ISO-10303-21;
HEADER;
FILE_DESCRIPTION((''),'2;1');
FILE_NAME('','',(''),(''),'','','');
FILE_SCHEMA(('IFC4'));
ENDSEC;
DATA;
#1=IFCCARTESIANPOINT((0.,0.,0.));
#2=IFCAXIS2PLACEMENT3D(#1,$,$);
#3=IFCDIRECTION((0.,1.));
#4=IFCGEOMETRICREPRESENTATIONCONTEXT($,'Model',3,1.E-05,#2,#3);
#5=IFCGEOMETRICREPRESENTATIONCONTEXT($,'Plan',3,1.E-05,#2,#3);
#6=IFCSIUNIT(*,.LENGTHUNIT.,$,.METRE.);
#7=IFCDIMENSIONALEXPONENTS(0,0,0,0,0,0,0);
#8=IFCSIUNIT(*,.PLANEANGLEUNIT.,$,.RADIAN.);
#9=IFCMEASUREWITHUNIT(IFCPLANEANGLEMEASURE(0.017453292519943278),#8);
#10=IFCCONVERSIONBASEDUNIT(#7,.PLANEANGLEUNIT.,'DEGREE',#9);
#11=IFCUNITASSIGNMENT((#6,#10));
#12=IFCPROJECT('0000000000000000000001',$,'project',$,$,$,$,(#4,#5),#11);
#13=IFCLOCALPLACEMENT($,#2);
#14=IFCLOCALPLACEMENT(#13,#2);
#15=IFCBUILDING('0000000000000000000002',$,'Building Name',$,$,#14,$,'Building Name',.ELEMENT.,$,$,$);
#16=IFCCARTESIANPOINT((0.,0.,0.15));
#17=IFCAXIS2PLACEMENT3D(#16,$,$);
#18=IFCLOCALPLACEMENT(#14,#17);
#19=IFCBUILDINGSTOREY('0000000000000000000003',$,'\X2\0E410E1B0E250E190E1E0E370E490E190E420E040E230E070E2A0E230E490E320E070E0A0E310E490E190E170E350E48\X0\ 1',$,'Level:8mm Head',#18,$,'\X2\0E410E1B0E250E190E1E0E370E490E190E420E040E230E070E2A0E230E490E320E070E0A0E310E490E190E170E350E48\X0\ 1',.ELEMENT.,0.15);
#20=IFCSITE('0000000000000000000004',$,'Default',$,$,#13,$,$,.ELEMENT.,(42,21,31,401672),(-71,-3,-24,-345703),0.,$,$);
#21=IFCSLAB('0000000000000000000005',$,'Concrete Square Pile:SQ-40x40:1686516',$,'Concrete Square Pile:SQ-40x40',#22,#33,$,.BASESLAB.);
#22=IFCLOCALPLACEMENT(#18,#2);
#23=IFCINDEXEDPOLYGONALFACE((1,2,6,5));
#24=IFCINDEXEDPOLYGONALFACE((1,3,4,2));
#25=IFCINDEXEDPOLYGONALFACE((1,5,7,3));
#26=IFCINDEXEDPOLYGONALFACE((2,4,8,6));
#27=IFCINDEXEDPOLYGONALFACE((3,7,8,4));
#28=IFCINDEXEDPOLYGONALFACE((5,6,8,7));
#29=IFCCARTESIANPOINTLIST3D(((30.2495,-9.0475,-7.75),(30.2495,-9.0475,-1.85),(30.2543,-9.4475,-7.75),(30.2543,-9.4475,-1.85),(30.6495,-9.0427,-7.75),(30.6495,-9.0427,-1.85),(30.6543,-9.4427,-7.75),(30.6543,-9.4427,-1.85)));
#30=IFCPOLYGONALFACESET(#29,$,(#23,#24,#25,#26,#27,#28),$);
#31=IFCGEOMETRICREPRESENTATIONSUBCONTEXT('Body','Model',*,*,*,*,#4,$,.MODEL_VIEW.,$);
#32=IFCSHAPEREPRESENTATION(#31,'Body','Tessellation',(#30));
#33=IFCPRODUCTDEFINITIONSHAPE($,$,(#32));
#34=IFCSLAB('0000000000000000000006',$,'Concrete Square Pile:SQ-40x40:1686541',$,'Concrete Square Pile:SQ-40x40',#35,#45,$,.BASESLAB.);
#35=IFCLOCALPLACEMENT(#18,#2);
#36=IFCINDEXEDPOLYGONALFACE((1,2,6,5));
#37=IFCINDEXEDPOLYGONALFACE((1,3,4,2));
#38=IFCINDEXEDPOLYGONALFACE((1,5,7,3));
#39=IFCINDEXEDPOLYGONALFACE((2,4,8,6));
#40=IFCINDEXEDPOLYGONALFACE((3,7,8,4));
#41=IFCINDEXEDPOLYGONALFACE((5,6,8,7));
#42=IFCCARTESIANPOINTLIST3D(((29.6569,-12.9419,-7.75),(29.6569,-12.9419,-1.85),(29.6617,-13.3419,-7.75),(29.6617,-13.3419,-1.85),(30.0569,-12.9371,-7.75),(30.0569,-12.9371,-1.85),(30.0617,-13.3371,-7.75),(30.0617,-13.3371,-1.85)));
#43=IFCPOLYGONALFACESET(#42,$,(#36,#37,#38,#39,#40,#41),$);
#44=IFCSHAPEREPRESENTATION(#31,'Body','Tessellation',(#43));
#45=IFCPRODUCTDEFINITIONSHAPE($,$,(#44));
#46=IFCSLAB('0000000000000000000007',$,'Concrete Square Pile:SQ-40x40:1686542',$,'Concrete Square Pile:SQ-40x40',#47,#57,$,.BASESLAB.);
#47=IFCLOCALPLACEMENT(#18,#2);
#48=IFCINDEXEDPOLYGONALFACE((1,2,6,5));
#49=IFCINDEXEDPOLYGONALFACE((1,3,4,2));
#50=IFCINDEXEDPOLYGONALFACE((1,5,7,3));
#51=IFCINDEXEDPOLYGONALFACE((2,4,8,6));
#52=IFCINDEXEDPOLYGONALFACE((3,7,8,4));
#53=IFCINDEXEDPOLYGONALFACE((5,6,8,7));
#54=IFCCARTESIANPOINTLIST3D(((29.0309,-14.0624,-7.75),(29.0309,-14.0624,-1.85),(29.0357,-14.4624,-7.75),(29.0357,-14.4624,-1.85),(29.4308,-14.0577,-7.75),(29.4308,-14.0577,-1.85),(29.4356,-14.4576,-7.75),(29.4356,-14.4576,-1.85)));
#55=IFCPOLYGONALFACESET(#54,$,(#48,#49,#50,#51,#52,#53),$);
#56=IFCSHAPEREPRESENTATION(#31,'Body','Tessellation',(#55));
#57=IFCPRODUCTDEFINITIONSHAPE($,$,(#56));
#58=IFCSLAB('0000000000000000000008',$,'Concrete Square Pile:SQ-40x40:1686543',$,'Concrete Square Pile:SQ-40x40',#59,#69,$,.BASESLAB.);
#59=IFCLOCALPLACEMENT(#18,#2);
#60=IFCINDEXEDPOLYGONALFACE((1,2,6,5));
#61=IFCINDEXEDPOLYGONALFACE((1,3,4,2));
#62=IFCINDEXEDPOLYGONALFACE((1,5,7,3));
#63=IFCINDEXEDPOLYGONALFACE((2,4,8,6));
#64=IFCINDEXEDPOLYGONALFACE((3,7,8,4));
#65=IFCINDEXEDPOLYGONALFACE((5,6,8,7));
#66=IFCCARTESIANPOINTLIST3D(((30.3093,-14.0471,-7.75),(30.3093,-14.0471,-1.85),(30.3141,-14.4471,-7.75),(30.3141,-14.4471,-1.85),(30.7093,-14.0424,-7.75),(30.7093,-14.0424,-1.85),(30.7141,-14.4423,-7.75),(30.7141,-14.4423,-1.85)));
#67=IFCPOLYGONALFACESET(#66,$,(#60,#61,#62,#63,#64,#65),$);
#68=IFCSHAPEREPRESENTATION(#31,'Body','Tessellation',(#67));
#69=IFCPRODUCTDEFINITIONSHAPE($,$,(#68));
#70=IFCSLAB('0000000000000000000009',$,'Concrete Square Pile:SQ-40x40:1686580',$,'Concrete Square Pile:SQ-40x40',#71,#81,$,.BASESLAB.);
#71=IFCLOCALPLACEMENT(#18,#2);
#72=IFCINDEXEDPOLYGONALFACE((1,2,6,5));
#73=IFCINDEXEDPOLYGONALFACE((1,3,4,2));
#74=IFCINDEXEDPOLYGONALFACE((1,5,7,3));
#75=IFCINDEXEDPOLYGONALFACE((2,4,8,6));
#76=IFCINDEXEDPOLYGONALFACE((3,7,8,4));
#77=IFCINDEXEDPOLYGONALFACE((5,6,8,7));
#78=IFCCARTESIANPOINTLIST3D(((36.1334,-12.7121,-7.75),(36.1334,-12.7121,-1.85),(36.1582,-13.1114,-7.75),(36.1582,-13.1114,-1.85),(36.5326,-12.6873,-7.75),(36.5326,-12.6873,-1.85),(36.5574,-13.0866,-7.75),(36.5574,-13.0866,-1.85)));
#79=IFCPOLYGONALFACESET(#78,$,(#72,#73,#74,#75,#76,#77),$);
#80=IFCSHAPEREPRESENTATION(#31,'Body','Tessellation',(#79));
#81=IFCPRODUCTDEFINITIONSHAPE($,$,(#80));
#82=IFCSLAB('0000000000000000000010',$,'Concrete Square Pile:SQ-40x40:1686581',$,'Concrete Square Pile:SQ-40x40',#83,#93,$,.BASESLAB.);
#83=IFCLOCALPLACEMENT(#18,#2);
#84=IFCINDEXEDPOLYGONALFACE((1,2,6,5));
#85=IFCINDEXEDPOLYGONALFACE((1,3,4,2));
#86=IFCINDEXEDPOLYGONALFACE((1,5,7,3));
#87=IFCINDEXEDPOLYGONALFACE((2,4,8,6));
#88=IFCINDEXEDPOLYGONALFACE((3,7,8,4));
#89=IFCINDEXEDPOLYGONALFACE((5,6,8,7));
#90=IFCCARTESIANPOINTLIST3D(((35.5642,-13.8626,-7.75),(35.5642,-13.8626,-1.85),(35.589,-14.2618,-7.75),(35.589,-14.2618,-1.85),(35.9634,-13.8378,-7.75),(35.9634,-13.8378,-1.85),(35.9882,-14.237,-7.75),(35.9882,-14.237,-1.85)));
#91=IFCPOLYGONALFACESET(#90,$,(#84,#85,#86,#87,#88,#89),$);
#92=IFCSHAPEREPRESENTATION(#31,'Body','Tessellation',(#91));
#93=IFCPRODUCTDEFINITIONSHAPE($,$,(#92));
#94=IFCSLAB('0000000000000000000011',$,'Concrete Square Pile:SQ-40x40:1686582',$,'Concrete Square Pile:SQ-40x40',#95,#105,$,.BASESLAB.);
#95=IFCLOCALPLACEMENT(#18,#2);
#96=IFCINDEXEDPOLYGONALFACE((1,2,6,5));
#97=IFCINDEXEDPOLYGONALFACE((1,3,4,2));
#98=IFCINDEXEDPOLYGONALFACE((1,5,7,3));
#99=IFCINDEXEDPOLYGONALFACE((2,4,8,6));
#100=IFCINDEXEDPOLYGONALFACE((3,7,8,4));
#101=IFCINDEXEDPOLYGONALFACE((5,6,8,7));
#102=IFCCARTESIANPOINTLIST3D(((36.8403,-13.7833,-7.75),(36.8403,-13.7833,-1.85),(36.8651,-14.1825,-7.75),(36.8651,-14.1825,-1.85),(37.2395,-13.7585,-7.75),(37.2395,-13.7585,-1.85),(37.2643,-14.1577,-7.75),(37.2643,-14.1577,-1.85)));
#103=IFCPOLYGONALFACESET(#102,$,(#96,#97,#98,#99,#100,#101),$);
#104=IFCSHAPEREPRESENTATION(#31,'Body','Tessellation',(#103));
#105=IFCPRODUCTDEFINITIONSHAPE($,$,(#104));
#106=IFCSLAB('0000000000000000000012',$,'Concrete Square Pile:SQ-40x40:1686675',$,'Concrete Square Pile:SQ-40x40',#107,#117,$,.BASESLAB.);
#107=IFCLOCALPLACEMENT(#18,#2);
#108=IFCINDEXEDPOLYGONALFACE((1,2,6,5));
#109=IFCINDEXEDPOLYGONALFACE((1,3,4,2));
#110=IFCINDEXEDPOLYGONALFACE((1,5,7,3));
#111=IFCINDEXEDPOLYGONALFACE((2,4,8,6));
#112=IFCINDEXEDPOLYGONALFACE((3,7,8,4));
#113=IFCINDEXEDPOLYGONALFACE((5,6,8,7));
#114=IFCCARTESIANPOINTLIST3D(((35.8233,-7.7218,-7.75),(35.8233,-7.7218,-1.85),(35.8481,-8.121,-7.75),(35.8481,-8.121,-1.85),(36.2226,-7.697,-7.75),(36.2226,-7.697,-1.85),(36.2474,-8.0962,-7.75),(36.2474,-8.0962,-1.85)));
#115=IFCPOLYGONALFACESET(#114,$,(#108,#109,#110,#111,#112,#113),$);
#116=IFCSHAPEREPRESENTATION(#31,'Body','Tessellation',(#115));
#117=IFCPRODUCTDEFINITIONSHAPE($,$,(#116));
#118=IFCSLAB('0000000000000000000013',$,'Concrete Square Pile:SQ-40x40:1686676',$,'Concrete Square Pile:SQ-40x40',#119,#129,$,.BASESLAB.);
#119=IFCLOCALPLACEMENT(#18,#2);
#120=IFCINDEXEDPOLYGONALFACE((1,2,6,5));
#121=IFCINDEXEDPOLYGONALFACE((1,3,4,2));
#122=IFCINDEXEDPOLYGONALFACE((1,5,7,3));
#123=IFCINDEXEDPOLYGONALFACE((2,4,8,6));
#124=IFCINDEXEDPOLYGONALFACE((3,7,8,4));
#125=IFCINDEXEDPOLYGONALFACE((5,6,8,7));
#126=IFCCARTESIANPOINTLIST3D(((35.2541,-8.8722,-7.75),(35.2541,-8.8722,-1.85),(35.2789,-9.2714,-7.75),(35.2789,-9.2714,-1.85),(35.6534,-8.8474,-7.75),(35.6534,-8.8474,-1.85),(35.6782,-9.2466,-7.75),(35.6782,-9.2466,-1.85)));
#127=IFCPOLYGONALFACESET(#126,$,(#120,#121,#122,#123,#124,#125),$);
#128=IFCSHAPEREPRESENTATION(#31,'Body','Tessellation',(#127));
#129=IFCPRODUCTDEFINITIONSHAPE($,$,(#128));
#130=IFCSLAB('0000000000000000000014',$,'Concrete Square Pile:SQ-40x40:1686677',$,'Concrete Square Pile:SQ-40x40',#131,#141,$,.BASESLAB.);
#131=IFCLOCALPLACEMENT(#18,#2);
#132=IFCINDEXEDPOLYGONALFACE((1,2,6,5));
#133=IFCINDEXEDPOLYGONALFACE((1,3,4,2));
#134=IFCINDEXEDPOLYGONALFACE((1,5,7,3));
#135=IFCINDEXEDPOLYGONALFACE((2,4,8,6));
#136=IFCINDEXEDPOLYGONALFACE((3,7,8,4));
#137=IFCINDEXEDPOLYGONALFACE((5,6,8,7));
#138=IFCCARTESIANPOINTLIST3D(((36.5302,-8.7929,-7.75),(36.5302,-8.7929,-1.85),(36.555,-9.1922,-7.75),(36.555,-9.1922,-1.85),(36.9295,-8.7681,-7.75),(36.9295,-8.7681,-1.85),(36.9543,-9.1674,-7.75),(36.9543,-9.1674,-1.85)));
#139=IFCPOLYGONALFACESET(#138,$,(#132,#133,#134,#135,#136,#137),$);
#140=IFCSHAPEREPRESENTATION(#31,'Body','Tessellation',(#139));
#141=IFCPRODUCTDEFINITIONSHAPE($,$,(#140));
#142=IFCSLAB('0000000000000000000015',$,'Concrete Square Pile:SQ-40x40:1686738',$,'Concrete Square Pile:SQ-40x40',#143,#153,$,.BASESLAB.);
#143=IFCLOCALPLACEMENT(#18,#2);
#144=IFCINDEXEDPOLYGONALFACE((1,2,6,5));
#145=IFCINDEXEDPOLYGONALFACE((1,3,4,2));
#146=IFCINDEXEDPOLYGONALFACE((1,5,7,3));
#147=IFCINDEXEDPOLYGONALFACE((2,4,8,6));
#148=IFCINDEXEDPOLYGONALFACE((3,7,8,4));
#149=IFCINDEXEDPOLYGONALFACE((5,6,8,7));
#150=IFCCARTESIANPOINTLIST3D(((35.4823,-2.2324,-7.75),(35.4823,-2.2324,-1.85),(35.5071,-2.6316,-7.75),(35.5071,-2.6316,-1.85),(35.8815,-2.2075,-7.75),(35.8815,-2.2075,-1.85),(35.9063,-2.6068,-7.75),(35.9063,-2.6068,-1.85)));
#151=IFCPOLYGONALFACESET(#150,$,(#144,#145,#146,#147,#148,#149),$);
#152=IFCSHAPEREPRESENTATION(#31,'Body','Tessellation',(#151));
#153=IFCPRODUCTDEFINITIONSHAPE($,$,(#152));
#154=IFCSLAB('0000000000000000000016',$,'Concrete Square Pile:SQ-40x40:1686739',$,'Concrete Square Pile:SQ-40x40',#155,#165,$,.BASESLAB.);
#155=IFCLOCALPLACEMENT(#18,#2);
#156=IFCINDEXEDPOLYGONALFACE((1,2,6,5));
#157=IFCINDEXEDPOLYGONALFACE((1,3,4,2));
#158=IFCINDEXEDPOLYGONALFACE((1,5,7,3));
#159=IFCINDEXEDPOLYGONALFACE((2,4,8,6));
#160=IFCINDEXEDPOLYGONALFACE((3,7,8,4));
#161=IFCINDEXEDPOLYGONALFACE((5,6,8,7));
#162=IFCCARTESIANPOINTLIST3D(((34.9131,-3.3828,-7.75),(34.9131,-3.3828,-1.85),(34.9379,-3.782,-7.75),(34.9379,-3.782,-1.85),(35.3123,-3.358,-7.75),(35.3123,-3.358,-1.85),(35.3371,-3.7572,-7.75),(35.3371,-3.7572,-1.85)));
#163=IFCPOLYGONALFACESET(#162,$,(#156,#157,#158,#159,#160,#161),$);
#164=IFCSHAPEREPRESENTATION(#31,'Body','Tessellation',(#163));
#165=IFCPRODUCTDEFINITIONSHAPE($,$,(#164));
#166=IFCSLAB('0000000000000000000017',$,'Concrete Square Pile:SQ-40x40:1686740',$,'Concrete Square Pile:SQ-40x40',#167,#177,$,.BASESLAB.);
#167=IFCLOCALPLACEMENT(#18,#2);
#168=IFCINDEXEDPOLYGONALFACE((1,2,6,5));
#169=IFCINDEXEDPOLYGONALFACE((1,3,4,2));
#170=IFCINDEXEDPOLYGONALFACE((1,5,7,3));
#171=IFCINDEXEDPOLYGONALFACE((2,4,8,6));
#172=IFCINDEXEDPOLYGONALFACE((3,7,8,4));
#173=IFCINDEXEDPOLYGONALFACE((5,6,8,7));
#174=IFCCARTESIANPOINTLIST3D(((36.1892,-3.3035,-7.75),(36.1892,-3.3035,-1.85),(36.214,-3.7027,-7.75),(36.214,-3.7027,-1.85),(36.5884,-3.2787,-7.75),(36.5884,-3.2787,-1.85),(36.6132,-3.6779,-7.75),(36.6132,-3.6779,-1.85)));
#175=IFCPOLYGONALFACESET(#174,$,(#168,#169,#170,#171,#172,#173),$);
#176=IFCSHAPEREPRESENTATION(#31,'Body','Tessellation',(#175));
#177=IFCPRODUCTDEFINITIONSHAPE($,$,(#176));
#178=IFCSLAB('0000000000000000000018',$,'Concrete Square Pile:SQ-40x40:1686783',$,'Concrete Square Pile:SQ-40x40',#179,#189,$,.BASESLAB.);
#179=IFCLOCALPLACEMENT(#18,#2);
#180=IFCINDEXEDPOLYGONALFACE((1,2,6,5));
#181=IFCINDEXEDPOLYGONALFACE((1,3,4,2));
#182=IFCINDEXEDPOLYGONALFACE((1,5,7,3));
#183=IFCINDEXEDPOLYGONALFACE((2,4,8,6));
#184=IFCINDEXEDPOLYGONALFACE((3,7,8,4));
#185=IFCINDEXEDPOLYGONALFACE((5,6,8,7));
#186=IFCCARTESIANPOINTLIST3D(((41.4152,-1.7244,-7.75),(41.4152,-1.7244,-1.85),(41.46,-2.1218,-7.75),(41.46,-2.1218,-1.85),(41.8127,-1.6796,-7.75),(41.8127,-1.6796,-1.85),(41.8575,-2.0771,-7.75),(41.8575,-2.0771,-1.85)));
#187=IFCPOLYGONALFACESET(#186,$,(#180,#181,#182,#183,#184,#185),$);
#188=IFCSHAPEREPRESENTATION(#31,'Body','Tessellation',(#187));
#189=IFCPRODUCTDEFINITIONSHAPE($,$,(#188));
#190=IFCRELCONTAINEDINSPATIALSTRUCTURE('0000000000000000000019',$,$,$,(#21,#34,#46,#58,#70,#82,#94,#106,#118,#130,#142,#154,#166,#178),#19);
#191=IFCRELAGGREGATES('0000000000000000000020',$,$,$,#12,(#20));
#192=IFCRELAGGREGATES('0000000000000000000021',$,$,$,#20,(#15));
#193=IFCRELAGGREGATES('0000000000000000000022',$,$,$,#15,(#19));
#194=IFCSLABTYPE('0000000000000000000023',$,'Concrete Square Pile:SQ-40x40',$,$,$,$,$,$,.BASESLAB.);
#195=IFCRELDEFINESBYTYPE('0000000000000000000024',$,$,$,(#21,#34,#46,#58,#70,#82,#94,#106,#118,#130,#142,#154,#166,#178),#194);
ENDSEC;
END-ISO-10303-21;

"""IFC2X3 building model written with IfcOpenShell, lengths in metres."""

from ifc_helpers import new_model, entity, si_unit, converted_unit, direction, frame, frame_2d, origin, place, context, subcontext, project, spatial, rectangle, extrude, type_object, element, save


model = new_model("IFC2X3")

# Units and contexts
model_context = context("Model", 3, precision=1e-05, world=origin(), true_north=direction((0.0, 1.0)))
plan_context = context("Plan", 3, precision=1e-05, world=origin(), true_north=direction((0.0, 1.0)))
body_context = subcontext(model_context, "Body", "Model", "MODEL_VIEW")
ifc_project = project(units=[si_unit("LENGTHUNIT", "METRE"), converted_unit("PLANEANGLEUNIT", "DEGREE", entity("IfcPlaneAngleMeasure", 0.017453292519943278), si_unit("PLANEANGLEUNIT", "RADIAN"), dimensions=[0, 0, 0, 0, 0, 0, 0])], contexts=[model_context, plan_context])

# Site, building, storey
site_placement = place(None, origin())
site = spatial("IfcSite", under=ifc_project, at=site_placement, Name="Default", CompositionType="ELEMENT", RefLatitude=(42, 21, 31, 401672), RefLongitude=(-71, -3, -24, -345703), RefElevation=0.0)
building_placement = place(site_placement, origin())
building = spatial("IfcBuilding", under=site, at=building_placement, Name="Building Name", LongName="Building Name", CompositionType="ELEMENT")
storey_placement = place(building_placement, frame((0.0, 0.0, 0.15)))
storey = spatial("IfcBuildingStorey", under=building, at=storey_placement, Name="แปลนพื้นโครงสร้างชั้นที่ 1", ObjectType="Level:8mm Head", LongName="แปลนพื้นโครงสร้างชั้นที่ 1", CompositionType="ELEMENT", Elevation=0.15)

# Slabs
slab_type_1 = type_object("IfcSlabType", Name="Concrete Square Pile:SQ-40x40", PredefinedType="BASESLAB")
slab_1_placement = place(storey_placement, origin())
element("IfcSlab", 1, at=slab_1_placement, inside=storey, type_object=slab_type_1, Name="Concrete Square Pile:SQ-40x40:1686516", ObjectType="Concrete Square Pile:SQ-40x40", PredefinedType="BASESLAB", context=body_context, shape_type="SweptSolid", body=[
    extrude(rectangle(XDim=0.4, YDim=0.4, at=frame_2d((0.0, 0.0), x_axis=(1.0, 0.0))), frame((30.4519, -9.2451, -7.75), z_axis=(0.0, 0.0, 1.0), x_axis=(-0.999928, -0.011969, 0.0)), (0.0, 0.0, 1.0), 5.9),
])
slab_2_placement = place(storey_placement, origin())
element("IfcSlab", 2, at=slab_2_placement, inside=storey, type_object=slab_type_1, Name="Concrete Square Pile:SQ-40x40:1686541", ObjectType="Concrete Square Pile:SQ-40x40", PredefinedType="BASESLAB", context=body_context, shape_type="SweptSolid", body=[
    extrude(rectangle(XDim=0.4, YDim=0.4, at=frame_2d((0.0, 0.0), x_axis=(1.0, 0.0))), frame((29.8593, -13.1395, -7.75), z_axis=(0.0, 0.0, 1.0), x_axis=(-0.999928, -0.011969, 0.0)), (0.0, 0.0, 1.0), 5.9),
])
slab_3_placement = place(storey_placement, origin())
element("IfcSlab", 3, at=slab_3_placement, inside=storey, type_object=slab_type_1, Name="Concrete Square Pile:SQ-40x40:1686542", ObjectType="Concrete Square Pile:SQ-40x40", PredefinedType="BASESLAB", context=body_context, shape_type="SweptSolid", body=[
    extrude(rectangle(XDim=0.4, YDim=0.4, at=frame_2d((0.0, 0.0), x_axis=(1.0, 0.0))), frame((29.2332, -14.26, -7.75), z_axis=(0.0, 0.0, 1.0), x_axis=(-0.999928, -0.011969, 0.0)), (0.0, 0.0, 1.0), 5.9),
])
slab_4_placement = place(storey_placement, origin())
element("IfcSlab", 4, at=slab_4_placement, inside=storey, type_object=slab_type_1, Name="Concrete Square Pile:SQ-40x40:1686543", ObjectType="Concrete Square Pile:SQ-40x40", PredefinedType="BASESLAB", context=body_context, shape_type="SweptSolid", body=[
    extrude(rectangle(XDim=0.4, YDim=0.4, at=frame_2d((0.0, 0.0), x_axis=(1.0, 0.0))), frame((30.5117, -14.2447, -7.75), z_axis=(0.0, 0.0, 1.0), x_axis=(-0.999928, -0.011969, 0.0)), (0.0, 0.0, 1.0), 5.9),
])
slab_5_placement = place(storey_placement, origin())
element("IfcSlab", 5, at=slab_5_placement, inside=storey, type_object=slab_type_1, Name="Concrete Square Pile:SQ-40x40:1686580", ObjectType="Concrete Square Pile:SQ-40x40", PredefinedType="BASESLAB", context=body_context, shape_type="SweptSolid", body=[
    extrude(rectangle(XDim=0.4, YDim=0.4, at=frame_2d((0.0, 0.0), x_axis=(1.0, 0.0))), frame((36.3454, -12.8994, -7.75), z_axis=(0.0, 0.0, 1.0), x_axis=(-0.998075, -0.062014, 0.0)), (0.0, 0.0, 1.0), 5.9),
])
slab_6_placement = place(storey_placement, origin())
element("IfcSlab", 6, at=slab_6_placement, inside=storey, type_object=slab_type_1, Name="Concrete Square Pile:SQ-40x40:1686581", ObjectType="Concrete Square Pile:SQ-40x40", PredefinedType="BASESLAB", context=body_context, shape_type="SweptSolid", body=[
    extrude(rectangle(XDim=0.4, YDim=0.4, at=frame_2d((0.0, 0.0), x_axis=(1.0, 0.0))), frame((35.7762, -14.0498, -7.75), z_axis=(0.0, 0.0, 1.0), x_axis=(-0.998075, -0.062014, 0.0)), (0.0, 0.0, 1.0), 5.9),
])
slab_7_placement = place(storey_placement, origin())
element("IfcSlab", 7, at=slab_7_placement, inside=storey, type_object=slab_type_1, Name="Concrete Square Pile:SQ-40x40:1686582", ObjectType="Concrete Square Pile:SQ-40x40", PredefinedType="BASESLAB", context=body_context, shape_type="SweptSolid", body=[
    extrude(rectangle(XDim=0.4, YDim=0.4, at=frame_2d((0.0, 0.0), x_axis=(1.0, 0.0))), frame((37.0523, -13.9705, -7.75), z_axis=(0.0, 0.0, 1.0), x_axis=(-0.998075, -0.062014, 0.0)), (0.0, 0.0, 1.0), 5.9),
])
slab_8_placement = place(storey_placement, origin())
element("IfcSlab", 8, at=slab_8_placement, inside=storey, type_object=slab_type_1, Name="Concrete Square Pile:SQ-40x40:1686675", ObjectType="Concrete Square Pile:SQ-40x40", PredefinedType="BASESLAB", context=body_context, shape_type="SweptSolid", body=[
    extrude(rectangle(XDim=0.4, YDim=0.4, at=frame_2d((0.0, 0.0), x_axis=(1.0, 0.0))), frame((36.0353, -7.909, -7.75), z_axis=(0.0, 0.0, 1.0), x_axis=(-0.998075, -0.062014, 0.0)), (0.0, 0.0, 1.0), 5.9),
])
slab_9_placement = place(storey_placement, origin())
element("IfcSlab", 9, at=slab_9_placement, inside=storey, type_object=slab_type_1, Name="Concrete Square Pile:SQ-40x40:1686676", ObjectType="Concrete Square Pile:SQ-40x40", PredefinedType="BASESLAB", context=body_context, shape_type="SweptSolid", body=[
    extrude(rectangle(XDim=0.4, YDim=0.4, at=frame_2d((0.0, 0.0), x_axis=(1.0, 0.0))), frame((35.4662, -9.0594, -7.75), z_axis=(0.0, 0.0, 1.0), x_axis=(-0.998075, -0.062014, 0.0)), (0.0, 0.0, 1.0), 5.9),
])
slab_10_placement = place(storey_placement, origin())
element("IfcSlab", 10, at=slab_10_placement, inside=storey, type_object=slab_type_1, Name="Concrete Square Pile:SQ-40x40:1686677", ObjectType="Concrete Square Pile:SQ-40x40", PredefinedType="BASESLAB", context=body_context, shape_type="SweptSolid", body=[
    extrude(rectangle(XDim=0.4, YDim=0.4, at=frame_2d((0.0, 0.0), x_axis=(1.0, 0.0))), frame((36.7423, -8.9801, -7.75), z_axis=(0.0, 0.0, 1.0), x_axis=(-0.998075, -0.062014, 0.0)), (0.0, 0.0, 1.0), 5.9),
])
slab_11_placement = place(storey_placement, origin())
element("IfcSlab", 11, at=slab_11_placement, inside=storey, type_object=slab_type_1, Name="Concrete Square Pile:SQ-40x40:1686738", ObjectType="Concrete Square Pile:SQ-40x40", PredefinedType="BASESLAB", context=body_context, shape_type="SweptSolid", body=[
    extrude(rectangle(XDim=0.4, YDim=0.4, at=frame_2d((0.0, 0.0), x_axis=(1.0, 0.0))), frame((35.6943, -2.4196, -7.75), z_axis=(0.0, 0.0, 1.0), x_axis=(-0.998075, -0.062014, 0.0)), (0.0, 0.0, 1.0), 5.9),
])
slab_12_placement = place(storey_placement, origin())
element("IfcSlab", 12, at=slab_12_placement, inside=storey, type_object=slab_type_1, Name="Concrete Square Pile:SQ-40x40:1686739", ObjectType="Concrete Square Pile:SQ-40x40", PredefinedType="BASESLAB", context=body_context, shape_type="SweptSolid", body=[
    extrude(rectangle(XDim=0.4, YDim=0.4, at=frame_2d((0.0, 0.0), x_axis=(1.0, 0.0))), frame((35.1251, -3.57, -7.75), z_axis=(0.0, 0.0, 1.0), x_axis=(-0.998075, -0.062014, 0.0)), (0.0, 0.0, 1.0), 5.9),
])
slab_13_placement = place(storey_placement, origin())
element("IfcSlab", 13, at=slab_13_placement, inside=storey, type_object=slab_type_1, Name="Concrete Square Pile:SQ-40x40:1686740", ObjectType="Concrete Square Pile:SQ-40x40", PredefinedType="BASESLAB", context=body_context, shape_type="SweptSolid", body=[
    extrude(rectangle(XDim=0.4, YDim=0.4, at=frame_2d((0.0, 0.0), x_axis=(1.0, 0.0))), frame((36.4012, -3.4907, -7.75), z_axis=(0.0, 0.0, 1.0), x_axis=(-0.998075, -0.062014, 0.0)), (0.0, 0.0, 1.0), 5.9),
])
slab_14_placement = place(storey_placement, origin())
element("IfcSlab", 14, at=slab_14_placement, inside=storey, type_object=slab_type_1, Name="Concrete Square Pile:SQ-40x40:1686783", ObjectType="Concrete Square Pile:SQ-40x40", PredefinedType="BASESLAB", context=body_context, shape_type="SweptSolid", body=[
    extrude(rectangle(XDim=0.4, YDim=0.4, at=frame_2d((0.0, 0.0), x_axis=(1.0, 0.0))), frame((41.6364, -1.9007, -7.75), z_axis=(0.0, 0.0, 1.0), x_axis=(-0.993719, -0.111904, 0.0)), (0.0, 0.0, 1.0), 5.9),
])

save(model, "model.ifc")
